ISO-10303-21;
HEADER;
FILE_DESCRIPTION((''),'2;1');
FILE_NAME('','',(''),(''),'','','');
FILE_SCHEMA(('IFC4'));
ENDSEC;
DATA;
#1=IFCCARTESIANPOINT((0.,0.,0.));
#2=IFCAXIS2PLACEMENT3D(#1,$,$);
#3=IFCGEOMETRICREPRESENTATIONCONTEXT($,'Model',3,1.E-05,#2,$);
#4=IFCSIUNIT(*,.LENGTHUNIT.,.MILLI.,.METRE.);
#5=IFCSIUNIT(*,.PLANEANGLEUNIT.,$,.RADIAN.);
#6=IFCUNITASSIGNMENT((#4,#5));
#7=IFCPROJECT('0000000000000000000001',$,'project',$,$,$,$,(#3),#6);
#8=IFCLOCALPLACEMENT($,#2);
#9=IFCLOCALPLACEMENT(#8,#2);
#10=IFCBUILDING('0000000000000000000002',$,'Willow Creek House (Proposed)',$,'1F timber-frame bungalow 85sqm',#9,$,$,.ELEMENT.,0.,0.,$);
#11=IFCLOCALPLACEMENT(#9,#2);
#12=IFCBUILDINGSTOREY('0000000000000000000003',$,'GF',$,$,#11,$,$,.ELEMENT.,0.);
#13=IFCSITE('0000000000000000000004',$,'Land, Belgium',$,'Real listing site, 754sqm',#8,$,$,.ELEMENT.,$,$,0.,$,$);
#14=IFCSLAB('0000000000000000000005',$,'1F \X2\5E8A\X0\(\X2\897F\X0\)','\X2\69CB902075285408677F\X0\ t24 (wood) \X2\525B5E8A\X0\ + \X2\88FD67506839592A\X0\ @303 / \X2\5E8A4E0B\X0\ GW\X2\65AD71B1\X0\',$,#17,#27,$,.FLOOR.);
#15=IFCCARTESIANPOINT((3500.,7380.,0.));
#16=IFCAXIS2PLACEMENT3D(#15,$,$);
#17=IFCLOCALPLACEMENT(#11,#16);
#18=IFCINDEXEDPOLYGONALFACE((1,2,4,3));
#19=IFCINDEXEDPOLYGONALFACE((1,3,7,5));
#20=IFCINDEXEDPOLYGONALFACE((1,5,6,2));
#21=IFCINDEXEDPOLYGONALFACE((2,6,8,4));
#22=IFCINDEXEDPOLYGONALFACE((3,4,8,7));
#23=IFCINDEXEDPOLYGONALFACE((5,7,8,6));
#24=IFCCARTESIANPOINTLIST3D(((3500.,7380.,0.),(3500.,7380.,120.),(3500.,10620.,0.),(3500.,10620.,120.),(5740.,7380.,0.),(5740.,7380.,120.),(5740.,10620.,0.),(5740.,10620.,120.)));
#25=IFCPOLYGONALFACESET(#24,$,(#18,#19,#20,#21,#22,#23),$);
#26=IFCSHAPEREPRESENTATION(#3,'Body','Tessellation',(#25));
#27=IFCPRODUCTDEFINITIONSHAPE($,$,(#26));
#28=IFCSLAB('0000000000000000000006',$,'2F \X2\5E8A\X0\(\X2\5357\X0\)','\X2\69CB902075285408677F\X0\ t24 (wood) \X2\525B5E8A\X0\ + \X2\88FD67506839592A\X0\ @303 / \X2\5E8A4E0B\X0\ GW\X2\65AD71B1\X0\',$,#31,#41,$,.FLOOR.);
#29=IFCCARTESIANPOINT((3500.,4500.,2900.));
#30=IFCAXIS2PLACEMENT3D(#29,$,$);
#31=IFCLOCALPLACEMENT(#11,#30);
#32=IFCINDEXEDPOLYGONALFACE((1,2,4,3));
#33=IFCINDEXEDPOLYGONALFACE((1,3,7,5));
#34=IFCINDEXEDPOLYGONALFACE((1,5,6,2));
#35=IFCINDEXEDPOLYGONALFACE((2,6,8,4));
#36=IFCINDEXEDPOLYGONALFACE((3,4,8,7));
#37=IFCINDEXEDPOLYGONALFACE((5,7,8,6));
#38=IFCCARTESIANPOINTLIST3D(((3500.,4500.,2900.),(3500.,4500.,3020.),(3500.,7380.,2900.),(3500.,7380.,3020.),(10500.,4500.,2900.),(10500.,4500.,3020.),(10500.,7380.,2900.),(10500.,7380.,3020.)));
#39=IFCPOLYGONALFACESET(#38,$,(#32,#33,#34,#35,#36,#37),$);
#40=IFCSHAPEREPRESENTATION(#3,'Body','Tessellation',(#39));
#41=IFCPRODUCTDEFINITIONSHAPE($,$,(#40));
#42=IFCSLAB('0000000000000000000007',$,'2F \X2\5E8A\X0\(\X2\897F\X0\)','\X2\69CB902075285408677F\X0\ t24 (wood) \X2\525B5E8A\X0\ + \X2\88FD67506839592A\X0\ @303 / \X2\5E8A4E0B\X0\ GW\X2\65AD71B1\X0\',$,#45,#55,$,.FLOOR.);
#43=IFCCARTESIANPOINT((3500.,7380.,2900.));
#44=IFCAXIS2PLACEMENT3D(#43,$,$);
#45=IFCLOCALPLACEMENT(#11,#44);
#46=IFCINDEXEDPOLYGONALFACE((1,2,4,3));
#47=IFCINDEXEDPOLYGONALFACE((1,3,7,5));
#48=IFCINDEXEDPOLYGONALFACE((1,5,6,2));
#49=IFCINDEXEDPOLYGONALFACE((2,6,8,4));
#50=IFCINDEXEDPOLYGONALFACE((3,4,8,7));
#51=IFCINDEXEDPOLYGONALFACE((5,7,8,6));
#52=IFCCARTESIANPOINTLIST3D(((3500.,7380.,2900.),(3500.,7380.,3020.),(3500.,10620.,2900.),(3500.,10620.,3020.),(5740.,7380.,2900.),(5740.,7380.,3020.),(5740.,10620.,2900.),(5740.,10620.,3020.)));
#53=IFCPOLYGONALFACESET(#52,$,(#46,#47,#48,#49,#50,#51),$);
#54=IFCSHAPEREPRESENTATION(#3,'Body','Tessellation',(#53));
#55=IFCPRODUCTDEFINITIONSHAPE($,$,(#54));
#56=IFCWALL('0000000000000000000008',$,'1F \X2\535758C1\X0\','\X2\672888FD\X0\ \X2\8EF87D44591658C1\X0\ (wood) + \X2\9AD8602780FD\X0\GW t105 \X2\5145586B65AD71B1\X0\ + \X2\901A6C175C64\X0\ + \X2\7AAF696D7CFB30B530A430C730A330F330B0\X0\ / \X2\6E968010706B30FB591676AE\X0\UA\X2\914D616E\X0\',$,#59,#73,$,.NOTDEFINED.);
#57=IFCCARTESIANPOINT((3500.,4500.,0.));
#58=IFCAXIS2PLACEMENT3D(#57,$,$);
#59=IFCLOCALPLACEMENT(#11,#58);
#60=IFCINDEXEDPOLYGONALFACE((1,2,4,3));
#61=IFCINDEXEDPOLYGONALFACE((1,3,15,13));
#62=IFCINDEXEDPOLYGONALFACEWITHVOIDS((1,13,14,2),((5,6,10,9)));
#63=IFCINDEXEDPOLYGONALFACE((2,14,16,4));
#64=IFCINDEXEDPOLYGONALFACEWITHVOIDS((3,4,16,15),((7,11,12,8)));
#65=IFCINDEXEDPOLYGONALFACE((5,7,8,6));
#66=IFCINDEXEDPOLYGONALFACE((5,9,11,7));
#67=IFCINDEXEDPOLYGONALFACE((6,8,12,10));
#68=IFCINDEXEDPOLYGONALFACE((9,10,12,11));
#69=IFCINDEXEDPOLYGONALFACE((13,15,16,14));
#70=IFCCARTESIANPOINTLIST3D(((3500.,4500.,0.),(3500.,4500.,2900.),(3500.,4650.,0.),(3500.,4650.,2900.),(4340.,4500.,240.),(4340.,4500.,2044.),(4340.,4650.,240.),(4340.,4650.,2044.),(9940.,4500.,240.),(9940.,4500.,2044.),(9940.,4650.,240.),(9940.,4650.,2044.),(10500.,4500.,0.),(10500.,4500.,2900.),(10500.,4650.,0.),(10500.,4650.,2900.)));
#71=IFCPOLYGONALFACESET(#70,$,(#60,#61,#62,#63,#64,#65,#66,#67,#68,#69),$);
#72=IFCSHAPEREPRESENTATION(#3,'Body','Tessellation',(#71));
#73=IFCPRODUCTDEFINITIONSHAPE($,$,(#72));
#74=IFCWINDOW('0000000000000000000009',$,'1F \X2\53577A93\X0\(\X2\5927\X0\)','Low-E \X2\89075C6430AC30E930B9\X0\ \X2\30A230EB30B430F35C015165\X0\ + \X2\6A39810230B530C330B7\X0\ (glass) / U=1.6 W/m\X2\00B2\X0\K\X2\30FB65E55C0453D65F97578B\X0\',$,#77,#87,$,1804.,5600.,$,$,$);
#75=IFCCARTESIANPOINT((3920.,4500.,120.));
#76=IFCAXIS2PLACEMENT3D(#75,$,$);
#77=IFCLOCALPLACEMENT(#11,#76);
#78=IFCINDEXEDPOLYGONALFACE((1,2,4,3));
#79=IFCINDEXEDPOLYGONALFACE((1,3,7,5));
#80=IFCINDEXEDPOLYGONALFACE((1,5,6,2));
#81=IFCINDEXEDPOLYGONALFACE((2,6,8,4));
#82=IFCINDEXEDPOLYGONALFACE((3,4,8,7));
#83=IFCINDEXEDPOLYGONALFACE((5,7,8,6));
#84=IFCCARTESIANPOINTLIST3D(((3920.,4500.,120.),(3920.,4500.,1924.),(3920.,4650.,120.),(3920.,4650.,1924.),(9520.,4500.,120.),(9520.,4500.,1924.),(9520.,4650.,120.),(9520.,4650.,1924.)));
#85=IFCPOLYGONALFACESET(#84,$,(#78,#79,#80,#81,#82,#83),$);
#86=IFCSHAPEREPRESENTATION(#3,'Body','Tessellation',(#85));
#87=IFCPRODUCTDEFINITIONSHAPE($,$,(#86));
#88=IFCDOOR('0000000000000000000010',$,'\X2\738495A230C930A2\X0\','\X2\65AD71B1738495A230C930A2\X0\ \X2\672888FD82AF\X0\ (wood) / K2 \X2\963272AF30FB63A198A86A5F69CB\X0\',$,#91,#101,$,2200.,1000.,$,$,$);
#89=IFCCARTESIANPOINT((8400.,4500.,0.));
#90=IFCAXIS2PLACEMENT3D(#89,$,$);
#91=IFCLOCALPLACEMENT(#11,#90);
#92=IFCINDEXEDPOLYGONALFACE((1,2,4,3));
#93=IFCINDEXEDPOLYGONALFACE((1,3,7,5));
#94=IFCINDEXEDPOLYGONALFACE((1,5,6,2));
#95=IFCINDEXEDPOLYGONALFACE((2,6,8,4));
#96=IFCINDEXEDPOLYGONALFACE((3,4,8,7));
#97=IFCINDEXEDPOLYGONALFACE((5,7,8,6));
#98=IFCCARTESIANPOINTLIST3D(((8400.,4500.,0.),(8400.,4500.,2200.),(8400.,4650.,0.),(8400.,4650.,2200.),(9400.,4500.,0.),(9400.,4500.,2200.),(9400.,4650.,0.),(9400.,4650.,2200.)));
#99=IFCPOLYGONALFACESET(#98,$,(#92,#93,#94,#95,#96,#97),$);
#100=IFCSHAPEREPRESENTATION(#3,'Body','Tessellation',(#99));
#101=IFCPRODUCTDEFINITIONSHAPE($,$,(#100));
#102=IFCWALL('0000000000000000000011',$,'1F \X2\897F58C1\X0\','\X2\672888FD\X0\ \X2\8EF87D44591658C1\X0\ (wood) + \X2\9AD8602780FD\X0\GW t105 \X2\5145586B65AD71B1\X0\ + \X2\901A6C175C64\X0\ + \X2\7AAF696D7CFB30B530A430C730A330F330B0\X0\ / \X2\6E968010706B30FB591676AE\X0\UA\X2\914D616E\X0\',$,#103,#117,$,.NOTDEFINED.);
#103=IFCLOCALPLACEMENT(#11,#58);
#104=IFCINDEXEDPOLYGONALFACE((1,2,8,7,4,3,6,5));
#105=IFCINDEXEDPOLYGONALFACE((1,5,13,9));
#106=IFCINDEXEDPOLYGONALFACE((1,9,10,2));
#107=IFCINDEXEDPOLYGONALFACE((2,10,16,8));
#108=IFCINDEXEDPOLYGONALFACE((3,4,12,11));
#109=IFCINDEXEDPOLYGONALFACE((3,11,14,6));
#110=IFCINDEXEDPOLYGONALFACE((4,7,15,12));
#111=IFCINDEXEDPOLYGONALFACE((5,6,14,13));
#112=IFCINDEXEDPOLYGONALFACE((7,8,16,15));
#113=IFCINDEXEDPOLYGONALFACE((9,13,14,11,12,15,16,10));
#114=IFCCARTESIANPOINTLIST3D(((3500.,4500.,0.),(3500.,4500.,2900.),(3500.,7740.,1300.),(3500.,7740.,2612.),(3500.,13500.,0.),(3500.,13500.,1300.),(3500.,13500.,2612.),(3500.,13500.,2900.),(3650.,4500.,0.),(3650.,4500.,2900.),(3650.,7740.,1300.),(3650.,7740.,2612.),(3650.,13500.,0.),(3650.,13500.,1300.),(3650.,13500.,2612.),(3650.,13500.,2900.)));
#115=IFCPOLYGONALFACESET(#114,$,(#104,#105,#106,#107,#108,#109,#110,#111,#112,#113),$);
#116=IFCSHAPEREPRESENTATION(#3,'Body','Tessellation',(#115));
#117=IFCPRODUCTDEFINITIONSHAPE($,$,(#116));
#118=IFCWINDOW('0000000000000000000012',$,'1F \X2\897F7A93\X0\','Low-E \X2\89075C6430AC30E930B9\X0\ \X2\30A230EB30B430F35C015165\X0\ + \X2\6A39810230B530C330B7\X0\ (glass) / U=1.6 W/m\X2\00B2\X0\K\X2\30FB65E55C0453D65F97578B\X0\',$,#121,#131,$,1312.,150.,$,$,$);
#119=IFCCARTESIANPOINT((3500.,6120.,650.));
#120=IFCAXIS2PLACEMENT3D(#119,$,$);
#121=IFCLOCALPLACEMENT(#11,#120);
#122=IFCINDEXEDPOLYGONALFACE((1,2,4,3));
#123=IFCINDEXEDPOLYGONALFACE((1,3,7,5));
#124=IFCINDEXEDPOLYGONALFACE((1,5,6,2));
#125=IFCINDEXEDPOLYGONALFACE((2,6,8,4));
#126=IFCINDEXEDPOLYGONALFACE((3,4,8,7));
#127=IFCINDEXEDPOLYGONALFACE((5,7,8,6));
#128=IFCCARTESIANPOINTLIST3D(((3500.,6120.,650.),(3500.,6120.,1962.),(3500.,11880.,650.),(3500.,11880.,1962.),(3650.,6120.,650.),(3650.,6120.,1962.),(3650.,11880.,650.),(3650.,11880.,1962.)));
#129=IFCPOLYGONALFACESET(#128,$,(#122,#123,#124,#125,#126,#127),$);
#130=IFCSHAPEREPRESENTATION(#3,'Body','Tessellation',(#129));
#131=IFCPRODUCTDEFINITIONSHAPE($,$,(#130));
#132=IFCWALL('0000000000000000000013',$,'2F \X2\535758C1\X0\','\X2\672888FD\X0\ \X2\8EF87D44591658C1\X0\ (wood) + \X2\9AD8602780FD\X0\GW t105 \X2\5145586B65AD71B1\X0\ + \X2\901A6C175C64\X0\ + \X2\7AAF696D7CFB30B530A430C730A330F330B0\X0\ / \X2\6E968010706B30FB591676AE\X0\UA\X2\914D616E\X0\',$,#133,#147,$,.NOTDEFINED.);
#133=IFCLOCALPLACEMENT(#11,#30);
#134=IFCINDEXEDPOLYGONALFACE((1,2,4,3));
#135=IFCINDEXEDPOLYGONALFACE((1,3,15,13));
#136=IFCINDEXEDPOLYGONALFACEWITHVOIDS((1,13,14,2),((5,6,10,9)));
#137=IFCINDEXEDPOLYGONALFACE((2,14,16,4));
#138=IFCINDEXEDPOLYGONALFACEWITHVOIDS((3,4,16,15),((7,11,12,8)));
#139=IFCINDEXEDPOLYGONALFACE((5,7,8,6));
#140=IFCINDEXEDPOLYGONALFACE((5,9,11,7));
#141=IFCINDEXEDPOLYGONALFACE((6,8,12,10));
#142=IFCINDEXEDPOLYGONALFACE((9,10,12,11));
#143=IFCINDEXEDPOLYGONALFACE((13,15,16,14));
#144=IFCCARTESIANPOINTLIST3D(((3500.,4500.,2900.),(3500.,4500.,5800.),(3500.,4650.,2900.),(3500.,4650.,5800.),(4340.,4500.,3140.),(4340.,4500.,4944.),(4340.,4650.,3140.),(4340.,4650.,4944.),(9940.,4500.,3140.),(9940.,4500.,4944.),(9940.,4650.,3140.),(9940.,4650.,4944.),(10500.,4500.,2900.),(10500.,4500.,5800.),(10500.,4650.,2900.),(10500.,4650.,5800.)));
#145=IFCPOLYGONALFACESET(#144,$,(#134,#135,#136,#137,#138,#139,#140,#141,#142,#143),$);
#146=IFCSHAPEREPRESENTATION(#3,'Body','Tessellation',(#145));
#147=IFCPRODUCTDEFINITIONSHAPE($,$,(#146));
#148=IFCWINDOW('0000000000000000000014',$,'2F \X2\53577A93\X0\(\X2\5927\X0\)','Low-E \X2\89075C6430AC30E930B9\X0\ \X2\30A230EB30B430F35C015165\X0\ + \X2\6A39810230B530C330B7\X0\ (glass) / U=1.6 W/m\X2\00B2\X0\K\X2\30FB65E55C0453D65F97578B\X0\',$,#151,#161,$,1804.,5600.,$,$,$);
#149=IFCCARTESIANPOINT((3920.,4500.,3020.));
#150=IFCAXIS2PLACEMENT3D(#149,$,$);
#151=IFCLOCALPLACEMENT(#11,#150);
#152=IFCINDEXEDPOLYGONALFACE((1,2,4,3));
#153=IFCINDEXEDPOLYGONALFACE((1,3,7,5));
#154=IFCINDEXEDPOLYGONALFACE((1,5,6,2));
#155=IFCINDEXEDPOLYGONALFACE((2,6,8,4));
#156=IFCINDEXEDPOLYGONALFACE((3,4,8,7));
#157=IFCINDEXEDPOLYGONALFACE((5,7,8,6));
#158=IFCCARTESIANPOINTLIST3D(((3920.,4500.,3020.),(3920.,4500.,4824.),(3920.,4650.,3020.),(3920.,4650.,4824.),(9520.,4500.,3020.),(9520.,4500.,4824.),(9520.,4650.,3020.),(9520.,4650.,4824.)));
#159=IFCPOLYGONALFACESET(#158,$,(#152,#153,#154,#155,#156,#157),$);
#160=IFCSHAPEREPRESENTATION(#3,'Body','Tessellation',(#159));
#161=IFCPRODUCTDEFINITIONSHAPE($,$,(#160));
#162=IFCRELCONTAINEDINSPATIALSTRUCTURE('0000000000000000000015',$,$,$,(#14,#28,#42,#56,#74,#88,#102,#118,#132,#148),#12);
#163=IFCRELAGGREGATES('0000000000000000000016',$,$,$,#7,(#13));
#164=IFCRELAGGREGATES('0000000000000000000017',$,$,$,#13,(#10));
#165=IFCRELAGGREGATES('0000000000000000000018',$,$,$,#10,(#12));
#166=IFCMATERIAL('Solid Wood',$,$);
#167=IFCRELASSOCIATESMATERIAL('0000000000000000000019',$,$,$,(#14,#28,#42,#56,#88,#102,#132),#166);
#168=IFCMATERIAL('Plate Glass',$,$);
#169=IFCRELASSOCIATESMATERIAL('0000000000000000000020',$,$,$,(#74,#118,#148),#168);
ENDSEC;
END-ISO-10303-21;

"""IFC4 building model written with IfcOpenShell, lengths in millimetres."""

from ifc_helpers import new_model, si_unit, frame, frame_2d, origin, place, context, project, spatial, rectangle, extrude, material, element, fill, save


model = new_model("IFC4")

# Units and contexts
model_context = context("Model", 3, precision=1e-05, world=origin())
ifc_project = project(units=[si_unit("LENGTHUNIT", "METRE", prefix="MILLI"), si_unit("PLANEANGLEUNIT", "RADIAN")], contexts=[model_context])

# Site, building, storey
site_placement = place(None, origin())
site = spatial("IfcSite", under=ifc_project, at=site_placement, Name="Land, Belgium", ObjectType="Real listing site, 754sqm", CompositionType="ELEMENT", RefElevation=0.0)
building_placement = place(site_placement, origin())
building = spatial("IfcBuilding", under=site, at=building_placement, Name="Willow Creek House (Proposed)", ObjectType="1F timber-frame bungalow 85sqm", CompositionType="ELEMENT", ElevationOfRefHeight=0.0, ElevationOfTerrain=0.0)
storey_placement = place(building_placement, origin())
storey = spatial("IfcBuildingStorey", under=building, at=storey_placement, Name="GF", CompositionType="ELEMENT", Elevation=0.0)

# Slabs
ifc_material_1 = material(Name="Solid Wood")
slab_1_placement = place(storey_placement, frame((3500.0, 7380.0, 0.0)))
element("IfcSlab", 1, at=slab_1_placement, inside=storey, material=ifc_material_1, Name="1F 床(西)", Description="構造用合板 t24 (wood) 剛床 + 製材根太 @303 / 床下 GW断熱", PredefinedType="FLOOR", context=model_context, shape_type="SweptSolid", body=[
    extrude(rectangle(XDim=2240.0, YDim=3240.0, at=frame_2d((1120.0, 1620.0))), frame((3500.0, 7380.0, 0.0)), (0.0, 0.0, 1.0), 120.0),
])
slab_2_placement = place(storey_placement, frame((3500.0, 4500.0, 2900.0)))
element("IfcSlab", 2, at=slab_2_placement, inside=storey, material=ifc_material_1, Name="2F 床(南)", Description="構造用合板 t24 (wood) 剛床 + 製材根太 @303 / 床下 GW断熱", PredefinedType="FLOOR", context=model_context, shape_type="SweptSolid", body=[
    extrude(rectangle(XDim=7000.0, YDim=2880.0, at=frame_2d((3500.0, 1440.0))), frame((3500.0, 4500.0, 2900.0)), (0.0, 0.0, 1.0), 120.0),
])
slab_3_placement = place(storey_placement, frame((3500.0, 7380.0, 2900.0)))
element("IfcSlab", 3, at=slab_3_placement, inside=storey, material=ifc_material_1, Name="2F 床(西)", Description="構造用合板 t24 (wood) 剛床 + 製材根太 @303 / 床下 GW断熱", PredefinedType="FLOOR", context=model_context, shape_type="SweptSolid", body=[
    extrude(rectangle(XDim=2240.0, YDim=3240.0, at=frame_2d((1120.0, 1620.0))), frame((3500.0, 7380.0, 2900.0)), (0.0, 0.0, 1.0), 120.0),
])

# Wall, openings, window, door
wall_1_placement = place(storey_placement, frame((3500.0, 4500.0, 0.0)))
wall_1 = element("IfcWall", 4, at=wall_1_placement, inside=storey, material=ifc_material_1, Name="1F 南壁", Description="木製 軸組外壁 (wood) + 高性能GW t105 充填断熱 + 通気層 + 窯業系サイディング / 準耐火・外皮UA配慮", PredefinedType="NOTDEFINED", context=model_context, shape_type="SweptSolid", body=[
    extrude(rectangle(XDim=7000.0, YDim=150.0, at=frame_2d((3500.0, 75.0))), frame((3500.0, 4500.0, 0.0)), (0.0, 0.0, 1.0), 2900.0),
])
opening_1_placement = place(storey_placement, frame((3920.0, 4500.0, 120.0)))
opening_1 = element("IfcOpeningElement", 5, at=opening_1_placement, cuts=wall_1, PredefinedType="NOTDEFINED", context=model_context, shape_type="SweptSolid", body=[
    extrude(rectangle(XDim=5600.0, YDim=150.0, at=frame_2d((2800.0, 75.0))), frame((3920.0, 4500.0, 120.0)), (0.0, 0.0, 1.0), 1804.0),
])
opening_2_placement = place(storey_placement, frame((8400.0, 4500.0, 0.0)))
opening_2 = element("IfcOpeningElement", 6, at=opening_2_placement, cuts=wall_1, PredefinedType="NOTDEFINED", context=model_context, shape_type="SweptSolid", body=[
    extrude(rectangle(XDim=1000.0, YDim=150.0, at=frame_2d((500.0, 75.0))), frame((8400.0, 4500.0, 0.0)), (0.0, 0.0, 1.0), 2200.0),
])
ifc_material_2 = material(Name="Plate Glass")
window_1_placement = place(storey_placement, frame((3920.0, 4500.0, 120.0)))
window_1 = element("IfcWindow", 7, at=window_1_placement, inside=storey, material=ifc_material_2, Name="1F 南窓(大)", Description="Low-E 複層ガラス アルゴン封入 + 樹脂サッシ (glass) / U=1.6 W/m²K・日射取得型", OverallHeight=1804.0, OverallWidth=5600.0, context=model_context, shape_type="SweptSolid", body=[
    extrude(rectangle(XDim=5600.0, YDim=150.0, at=frame_2d((2800.0, 75.0))), frame((3920.0, 4500.0, 120.0)), (0.0, 0.0, 1.0), 1804.0),
])
fill(opening_1, window_1)
door_placement = place(storey_placement, frame((8400.0, 4500.0, 0.0)))
door = element("IfcDoor", 8, at=door_placement, inside=storey, material=ifc_material_1, Name="玄関ドア", Description="断熱玄関ドア 木製芯 (wood) / K2 防犯・採風機構", OverallHeight=2200.0, OverallWidth=1000.0, context=model_context, shape_type="SweptSolid", body=[
    extrude(rectangle(XDim=1000.0, YDim=150.0, at=frame_2d((500.0, 75.0))), frame((8400.0, 4500.0, 0.0)), (0.0, 0.0, 1.0), 2200.0),
])
fill(opening_2, door)

# Walls, openings, windows
wall_2_placement = place(storey_placement, frame((3500.0, 4500.0, 0.0)))
wall_2 = element("IfcWall", 9, at=wall_2_placement, inside=storey, material=ifc_material_1, Name="1F 西壁", Description="木製 軸組外壁 (wood) + 高性能GW t105 充填断熱 + 通気層 + 窯業系サイディング / 準耐火・外皮UA配慮", PredefinedType="NOTDEFINED", context=model_context, shape_type="SweptSolid", body=[
    extrude(rectangle(XDim=150.0, YDim=9000.0, at=frame_2d((75.0, 4500.0))), frame((3500.0, 4500.0, 0.0)), (0.0, 0.0, 1.0), 2900.0),
])
opening_3_placement = place(storey_placement, frame((3500.0, 6120.0, 650.0)))
opening_3 = element("IfcOpeningElement", 10, at=opening_3_placement, cuts=wall_2, PredefinedType="NOTDEFINED", context=model_context, shape_type="SweptSolid", body=[
    extrude(rectangle(XDim=150.0, YDim=5760.0, at=frame_2d((75.0, 2880.0))), frame((3500.0, 6120.0, 650.0)), (0.0, 0.0, 1.0), 1312.0),
])
window_2_placement = place(storey_placement, frame((3500.0, 6120.0, 650.0)))
window_2 = element("IfcWindow", 11, at=window_2_placement, inside=storey, material=ifc_material_2, Name="1F 西窓", Description="Low-E 複層ガラス アルゴン封入 + 樹脂サッシ (glass) / U=1.6 W/m²K・日射取得型", OverallHeight=1312.0, OverallWidth=150.0, context=model_context, shape_type="SweptSolid", body=[
    extrude(rectangle(XDim=150.0, YDim=5760.0, at=frame_2d((75.0, 2880.0))), frame((3500.0, 6120.0, 650.0)), (0.0, 0.0, 1.0), 1312.0),
])
fill(opening_3, window_2)
wall_3_placement = place(storey_placement, frame((3500.0, 4500.0, 2900.0)))
wall_3 = element("IfcWall", 12, at=wall_3_placement, inside=storey, material=ifc_material_1, Name="2F 南壁", Description="木製 軸組外壁 (wood) + 高性能GW t105 充填断熱 + 通気層 + 窯業系サイディング / 準耐火・外皮UA配慮", PredefinedType="NOTDEFINED", context=model_context, shape_type="SweptSolid", body=[
    extrude(rectangle(XDim=7000.0, YDim=150.0, at=frame_2d((3500.0, 75.0))), frame((3500.0, 4500.0, 2900.0)), (0.0, 0.0, 1.0), 2900.0),
])
opening_4_placement = place(storey_placement, frame((3920.0, 4500.0, 3020.0)))
opening_4 = element("IfcOpeningElement", 13, at=opening_4_placement, cuts=wall_3, PredefinedType="NOTDEFINED", context=model_context, shape_type="SweptSolid", body=[
    extrude(rectangle(XDim=5600.0, YDim=150.0, at=frame_2d((2800.0, 75.0))), frame((3920.0, 4500.0, 3020.0)), (0.0, 0.0, 1.0), 1804.0),
])
window_3_placement = place(storey_placement, frame((3920.0, 4500.0, 3020.0)))
window_3 = element("IfcWindow", 14, at=window_3_placement, inside=storey, material=ifc_material_2, Name="2F 南窓(大)", Description="Low-E 複層ガラス アルゴン封入 + 樹脂サッシ (glass) / U=1.6 W/m²K・日射取得型", OverallHeight=1804.0, OverallWidth=5600.0, context=model_context, shape_type="SweptSolid", body=[
    extrude(rectangle(XDim=5600.0, YDim=150.0, at=frame_2d((2800.0, 75.0))), frame((3920.0, 4500.0, 3020.0)), (0.0, 0.0, 1.0), 1804.0),
])
fill(opening_4, window_3)

save(model, "model.ifc")
